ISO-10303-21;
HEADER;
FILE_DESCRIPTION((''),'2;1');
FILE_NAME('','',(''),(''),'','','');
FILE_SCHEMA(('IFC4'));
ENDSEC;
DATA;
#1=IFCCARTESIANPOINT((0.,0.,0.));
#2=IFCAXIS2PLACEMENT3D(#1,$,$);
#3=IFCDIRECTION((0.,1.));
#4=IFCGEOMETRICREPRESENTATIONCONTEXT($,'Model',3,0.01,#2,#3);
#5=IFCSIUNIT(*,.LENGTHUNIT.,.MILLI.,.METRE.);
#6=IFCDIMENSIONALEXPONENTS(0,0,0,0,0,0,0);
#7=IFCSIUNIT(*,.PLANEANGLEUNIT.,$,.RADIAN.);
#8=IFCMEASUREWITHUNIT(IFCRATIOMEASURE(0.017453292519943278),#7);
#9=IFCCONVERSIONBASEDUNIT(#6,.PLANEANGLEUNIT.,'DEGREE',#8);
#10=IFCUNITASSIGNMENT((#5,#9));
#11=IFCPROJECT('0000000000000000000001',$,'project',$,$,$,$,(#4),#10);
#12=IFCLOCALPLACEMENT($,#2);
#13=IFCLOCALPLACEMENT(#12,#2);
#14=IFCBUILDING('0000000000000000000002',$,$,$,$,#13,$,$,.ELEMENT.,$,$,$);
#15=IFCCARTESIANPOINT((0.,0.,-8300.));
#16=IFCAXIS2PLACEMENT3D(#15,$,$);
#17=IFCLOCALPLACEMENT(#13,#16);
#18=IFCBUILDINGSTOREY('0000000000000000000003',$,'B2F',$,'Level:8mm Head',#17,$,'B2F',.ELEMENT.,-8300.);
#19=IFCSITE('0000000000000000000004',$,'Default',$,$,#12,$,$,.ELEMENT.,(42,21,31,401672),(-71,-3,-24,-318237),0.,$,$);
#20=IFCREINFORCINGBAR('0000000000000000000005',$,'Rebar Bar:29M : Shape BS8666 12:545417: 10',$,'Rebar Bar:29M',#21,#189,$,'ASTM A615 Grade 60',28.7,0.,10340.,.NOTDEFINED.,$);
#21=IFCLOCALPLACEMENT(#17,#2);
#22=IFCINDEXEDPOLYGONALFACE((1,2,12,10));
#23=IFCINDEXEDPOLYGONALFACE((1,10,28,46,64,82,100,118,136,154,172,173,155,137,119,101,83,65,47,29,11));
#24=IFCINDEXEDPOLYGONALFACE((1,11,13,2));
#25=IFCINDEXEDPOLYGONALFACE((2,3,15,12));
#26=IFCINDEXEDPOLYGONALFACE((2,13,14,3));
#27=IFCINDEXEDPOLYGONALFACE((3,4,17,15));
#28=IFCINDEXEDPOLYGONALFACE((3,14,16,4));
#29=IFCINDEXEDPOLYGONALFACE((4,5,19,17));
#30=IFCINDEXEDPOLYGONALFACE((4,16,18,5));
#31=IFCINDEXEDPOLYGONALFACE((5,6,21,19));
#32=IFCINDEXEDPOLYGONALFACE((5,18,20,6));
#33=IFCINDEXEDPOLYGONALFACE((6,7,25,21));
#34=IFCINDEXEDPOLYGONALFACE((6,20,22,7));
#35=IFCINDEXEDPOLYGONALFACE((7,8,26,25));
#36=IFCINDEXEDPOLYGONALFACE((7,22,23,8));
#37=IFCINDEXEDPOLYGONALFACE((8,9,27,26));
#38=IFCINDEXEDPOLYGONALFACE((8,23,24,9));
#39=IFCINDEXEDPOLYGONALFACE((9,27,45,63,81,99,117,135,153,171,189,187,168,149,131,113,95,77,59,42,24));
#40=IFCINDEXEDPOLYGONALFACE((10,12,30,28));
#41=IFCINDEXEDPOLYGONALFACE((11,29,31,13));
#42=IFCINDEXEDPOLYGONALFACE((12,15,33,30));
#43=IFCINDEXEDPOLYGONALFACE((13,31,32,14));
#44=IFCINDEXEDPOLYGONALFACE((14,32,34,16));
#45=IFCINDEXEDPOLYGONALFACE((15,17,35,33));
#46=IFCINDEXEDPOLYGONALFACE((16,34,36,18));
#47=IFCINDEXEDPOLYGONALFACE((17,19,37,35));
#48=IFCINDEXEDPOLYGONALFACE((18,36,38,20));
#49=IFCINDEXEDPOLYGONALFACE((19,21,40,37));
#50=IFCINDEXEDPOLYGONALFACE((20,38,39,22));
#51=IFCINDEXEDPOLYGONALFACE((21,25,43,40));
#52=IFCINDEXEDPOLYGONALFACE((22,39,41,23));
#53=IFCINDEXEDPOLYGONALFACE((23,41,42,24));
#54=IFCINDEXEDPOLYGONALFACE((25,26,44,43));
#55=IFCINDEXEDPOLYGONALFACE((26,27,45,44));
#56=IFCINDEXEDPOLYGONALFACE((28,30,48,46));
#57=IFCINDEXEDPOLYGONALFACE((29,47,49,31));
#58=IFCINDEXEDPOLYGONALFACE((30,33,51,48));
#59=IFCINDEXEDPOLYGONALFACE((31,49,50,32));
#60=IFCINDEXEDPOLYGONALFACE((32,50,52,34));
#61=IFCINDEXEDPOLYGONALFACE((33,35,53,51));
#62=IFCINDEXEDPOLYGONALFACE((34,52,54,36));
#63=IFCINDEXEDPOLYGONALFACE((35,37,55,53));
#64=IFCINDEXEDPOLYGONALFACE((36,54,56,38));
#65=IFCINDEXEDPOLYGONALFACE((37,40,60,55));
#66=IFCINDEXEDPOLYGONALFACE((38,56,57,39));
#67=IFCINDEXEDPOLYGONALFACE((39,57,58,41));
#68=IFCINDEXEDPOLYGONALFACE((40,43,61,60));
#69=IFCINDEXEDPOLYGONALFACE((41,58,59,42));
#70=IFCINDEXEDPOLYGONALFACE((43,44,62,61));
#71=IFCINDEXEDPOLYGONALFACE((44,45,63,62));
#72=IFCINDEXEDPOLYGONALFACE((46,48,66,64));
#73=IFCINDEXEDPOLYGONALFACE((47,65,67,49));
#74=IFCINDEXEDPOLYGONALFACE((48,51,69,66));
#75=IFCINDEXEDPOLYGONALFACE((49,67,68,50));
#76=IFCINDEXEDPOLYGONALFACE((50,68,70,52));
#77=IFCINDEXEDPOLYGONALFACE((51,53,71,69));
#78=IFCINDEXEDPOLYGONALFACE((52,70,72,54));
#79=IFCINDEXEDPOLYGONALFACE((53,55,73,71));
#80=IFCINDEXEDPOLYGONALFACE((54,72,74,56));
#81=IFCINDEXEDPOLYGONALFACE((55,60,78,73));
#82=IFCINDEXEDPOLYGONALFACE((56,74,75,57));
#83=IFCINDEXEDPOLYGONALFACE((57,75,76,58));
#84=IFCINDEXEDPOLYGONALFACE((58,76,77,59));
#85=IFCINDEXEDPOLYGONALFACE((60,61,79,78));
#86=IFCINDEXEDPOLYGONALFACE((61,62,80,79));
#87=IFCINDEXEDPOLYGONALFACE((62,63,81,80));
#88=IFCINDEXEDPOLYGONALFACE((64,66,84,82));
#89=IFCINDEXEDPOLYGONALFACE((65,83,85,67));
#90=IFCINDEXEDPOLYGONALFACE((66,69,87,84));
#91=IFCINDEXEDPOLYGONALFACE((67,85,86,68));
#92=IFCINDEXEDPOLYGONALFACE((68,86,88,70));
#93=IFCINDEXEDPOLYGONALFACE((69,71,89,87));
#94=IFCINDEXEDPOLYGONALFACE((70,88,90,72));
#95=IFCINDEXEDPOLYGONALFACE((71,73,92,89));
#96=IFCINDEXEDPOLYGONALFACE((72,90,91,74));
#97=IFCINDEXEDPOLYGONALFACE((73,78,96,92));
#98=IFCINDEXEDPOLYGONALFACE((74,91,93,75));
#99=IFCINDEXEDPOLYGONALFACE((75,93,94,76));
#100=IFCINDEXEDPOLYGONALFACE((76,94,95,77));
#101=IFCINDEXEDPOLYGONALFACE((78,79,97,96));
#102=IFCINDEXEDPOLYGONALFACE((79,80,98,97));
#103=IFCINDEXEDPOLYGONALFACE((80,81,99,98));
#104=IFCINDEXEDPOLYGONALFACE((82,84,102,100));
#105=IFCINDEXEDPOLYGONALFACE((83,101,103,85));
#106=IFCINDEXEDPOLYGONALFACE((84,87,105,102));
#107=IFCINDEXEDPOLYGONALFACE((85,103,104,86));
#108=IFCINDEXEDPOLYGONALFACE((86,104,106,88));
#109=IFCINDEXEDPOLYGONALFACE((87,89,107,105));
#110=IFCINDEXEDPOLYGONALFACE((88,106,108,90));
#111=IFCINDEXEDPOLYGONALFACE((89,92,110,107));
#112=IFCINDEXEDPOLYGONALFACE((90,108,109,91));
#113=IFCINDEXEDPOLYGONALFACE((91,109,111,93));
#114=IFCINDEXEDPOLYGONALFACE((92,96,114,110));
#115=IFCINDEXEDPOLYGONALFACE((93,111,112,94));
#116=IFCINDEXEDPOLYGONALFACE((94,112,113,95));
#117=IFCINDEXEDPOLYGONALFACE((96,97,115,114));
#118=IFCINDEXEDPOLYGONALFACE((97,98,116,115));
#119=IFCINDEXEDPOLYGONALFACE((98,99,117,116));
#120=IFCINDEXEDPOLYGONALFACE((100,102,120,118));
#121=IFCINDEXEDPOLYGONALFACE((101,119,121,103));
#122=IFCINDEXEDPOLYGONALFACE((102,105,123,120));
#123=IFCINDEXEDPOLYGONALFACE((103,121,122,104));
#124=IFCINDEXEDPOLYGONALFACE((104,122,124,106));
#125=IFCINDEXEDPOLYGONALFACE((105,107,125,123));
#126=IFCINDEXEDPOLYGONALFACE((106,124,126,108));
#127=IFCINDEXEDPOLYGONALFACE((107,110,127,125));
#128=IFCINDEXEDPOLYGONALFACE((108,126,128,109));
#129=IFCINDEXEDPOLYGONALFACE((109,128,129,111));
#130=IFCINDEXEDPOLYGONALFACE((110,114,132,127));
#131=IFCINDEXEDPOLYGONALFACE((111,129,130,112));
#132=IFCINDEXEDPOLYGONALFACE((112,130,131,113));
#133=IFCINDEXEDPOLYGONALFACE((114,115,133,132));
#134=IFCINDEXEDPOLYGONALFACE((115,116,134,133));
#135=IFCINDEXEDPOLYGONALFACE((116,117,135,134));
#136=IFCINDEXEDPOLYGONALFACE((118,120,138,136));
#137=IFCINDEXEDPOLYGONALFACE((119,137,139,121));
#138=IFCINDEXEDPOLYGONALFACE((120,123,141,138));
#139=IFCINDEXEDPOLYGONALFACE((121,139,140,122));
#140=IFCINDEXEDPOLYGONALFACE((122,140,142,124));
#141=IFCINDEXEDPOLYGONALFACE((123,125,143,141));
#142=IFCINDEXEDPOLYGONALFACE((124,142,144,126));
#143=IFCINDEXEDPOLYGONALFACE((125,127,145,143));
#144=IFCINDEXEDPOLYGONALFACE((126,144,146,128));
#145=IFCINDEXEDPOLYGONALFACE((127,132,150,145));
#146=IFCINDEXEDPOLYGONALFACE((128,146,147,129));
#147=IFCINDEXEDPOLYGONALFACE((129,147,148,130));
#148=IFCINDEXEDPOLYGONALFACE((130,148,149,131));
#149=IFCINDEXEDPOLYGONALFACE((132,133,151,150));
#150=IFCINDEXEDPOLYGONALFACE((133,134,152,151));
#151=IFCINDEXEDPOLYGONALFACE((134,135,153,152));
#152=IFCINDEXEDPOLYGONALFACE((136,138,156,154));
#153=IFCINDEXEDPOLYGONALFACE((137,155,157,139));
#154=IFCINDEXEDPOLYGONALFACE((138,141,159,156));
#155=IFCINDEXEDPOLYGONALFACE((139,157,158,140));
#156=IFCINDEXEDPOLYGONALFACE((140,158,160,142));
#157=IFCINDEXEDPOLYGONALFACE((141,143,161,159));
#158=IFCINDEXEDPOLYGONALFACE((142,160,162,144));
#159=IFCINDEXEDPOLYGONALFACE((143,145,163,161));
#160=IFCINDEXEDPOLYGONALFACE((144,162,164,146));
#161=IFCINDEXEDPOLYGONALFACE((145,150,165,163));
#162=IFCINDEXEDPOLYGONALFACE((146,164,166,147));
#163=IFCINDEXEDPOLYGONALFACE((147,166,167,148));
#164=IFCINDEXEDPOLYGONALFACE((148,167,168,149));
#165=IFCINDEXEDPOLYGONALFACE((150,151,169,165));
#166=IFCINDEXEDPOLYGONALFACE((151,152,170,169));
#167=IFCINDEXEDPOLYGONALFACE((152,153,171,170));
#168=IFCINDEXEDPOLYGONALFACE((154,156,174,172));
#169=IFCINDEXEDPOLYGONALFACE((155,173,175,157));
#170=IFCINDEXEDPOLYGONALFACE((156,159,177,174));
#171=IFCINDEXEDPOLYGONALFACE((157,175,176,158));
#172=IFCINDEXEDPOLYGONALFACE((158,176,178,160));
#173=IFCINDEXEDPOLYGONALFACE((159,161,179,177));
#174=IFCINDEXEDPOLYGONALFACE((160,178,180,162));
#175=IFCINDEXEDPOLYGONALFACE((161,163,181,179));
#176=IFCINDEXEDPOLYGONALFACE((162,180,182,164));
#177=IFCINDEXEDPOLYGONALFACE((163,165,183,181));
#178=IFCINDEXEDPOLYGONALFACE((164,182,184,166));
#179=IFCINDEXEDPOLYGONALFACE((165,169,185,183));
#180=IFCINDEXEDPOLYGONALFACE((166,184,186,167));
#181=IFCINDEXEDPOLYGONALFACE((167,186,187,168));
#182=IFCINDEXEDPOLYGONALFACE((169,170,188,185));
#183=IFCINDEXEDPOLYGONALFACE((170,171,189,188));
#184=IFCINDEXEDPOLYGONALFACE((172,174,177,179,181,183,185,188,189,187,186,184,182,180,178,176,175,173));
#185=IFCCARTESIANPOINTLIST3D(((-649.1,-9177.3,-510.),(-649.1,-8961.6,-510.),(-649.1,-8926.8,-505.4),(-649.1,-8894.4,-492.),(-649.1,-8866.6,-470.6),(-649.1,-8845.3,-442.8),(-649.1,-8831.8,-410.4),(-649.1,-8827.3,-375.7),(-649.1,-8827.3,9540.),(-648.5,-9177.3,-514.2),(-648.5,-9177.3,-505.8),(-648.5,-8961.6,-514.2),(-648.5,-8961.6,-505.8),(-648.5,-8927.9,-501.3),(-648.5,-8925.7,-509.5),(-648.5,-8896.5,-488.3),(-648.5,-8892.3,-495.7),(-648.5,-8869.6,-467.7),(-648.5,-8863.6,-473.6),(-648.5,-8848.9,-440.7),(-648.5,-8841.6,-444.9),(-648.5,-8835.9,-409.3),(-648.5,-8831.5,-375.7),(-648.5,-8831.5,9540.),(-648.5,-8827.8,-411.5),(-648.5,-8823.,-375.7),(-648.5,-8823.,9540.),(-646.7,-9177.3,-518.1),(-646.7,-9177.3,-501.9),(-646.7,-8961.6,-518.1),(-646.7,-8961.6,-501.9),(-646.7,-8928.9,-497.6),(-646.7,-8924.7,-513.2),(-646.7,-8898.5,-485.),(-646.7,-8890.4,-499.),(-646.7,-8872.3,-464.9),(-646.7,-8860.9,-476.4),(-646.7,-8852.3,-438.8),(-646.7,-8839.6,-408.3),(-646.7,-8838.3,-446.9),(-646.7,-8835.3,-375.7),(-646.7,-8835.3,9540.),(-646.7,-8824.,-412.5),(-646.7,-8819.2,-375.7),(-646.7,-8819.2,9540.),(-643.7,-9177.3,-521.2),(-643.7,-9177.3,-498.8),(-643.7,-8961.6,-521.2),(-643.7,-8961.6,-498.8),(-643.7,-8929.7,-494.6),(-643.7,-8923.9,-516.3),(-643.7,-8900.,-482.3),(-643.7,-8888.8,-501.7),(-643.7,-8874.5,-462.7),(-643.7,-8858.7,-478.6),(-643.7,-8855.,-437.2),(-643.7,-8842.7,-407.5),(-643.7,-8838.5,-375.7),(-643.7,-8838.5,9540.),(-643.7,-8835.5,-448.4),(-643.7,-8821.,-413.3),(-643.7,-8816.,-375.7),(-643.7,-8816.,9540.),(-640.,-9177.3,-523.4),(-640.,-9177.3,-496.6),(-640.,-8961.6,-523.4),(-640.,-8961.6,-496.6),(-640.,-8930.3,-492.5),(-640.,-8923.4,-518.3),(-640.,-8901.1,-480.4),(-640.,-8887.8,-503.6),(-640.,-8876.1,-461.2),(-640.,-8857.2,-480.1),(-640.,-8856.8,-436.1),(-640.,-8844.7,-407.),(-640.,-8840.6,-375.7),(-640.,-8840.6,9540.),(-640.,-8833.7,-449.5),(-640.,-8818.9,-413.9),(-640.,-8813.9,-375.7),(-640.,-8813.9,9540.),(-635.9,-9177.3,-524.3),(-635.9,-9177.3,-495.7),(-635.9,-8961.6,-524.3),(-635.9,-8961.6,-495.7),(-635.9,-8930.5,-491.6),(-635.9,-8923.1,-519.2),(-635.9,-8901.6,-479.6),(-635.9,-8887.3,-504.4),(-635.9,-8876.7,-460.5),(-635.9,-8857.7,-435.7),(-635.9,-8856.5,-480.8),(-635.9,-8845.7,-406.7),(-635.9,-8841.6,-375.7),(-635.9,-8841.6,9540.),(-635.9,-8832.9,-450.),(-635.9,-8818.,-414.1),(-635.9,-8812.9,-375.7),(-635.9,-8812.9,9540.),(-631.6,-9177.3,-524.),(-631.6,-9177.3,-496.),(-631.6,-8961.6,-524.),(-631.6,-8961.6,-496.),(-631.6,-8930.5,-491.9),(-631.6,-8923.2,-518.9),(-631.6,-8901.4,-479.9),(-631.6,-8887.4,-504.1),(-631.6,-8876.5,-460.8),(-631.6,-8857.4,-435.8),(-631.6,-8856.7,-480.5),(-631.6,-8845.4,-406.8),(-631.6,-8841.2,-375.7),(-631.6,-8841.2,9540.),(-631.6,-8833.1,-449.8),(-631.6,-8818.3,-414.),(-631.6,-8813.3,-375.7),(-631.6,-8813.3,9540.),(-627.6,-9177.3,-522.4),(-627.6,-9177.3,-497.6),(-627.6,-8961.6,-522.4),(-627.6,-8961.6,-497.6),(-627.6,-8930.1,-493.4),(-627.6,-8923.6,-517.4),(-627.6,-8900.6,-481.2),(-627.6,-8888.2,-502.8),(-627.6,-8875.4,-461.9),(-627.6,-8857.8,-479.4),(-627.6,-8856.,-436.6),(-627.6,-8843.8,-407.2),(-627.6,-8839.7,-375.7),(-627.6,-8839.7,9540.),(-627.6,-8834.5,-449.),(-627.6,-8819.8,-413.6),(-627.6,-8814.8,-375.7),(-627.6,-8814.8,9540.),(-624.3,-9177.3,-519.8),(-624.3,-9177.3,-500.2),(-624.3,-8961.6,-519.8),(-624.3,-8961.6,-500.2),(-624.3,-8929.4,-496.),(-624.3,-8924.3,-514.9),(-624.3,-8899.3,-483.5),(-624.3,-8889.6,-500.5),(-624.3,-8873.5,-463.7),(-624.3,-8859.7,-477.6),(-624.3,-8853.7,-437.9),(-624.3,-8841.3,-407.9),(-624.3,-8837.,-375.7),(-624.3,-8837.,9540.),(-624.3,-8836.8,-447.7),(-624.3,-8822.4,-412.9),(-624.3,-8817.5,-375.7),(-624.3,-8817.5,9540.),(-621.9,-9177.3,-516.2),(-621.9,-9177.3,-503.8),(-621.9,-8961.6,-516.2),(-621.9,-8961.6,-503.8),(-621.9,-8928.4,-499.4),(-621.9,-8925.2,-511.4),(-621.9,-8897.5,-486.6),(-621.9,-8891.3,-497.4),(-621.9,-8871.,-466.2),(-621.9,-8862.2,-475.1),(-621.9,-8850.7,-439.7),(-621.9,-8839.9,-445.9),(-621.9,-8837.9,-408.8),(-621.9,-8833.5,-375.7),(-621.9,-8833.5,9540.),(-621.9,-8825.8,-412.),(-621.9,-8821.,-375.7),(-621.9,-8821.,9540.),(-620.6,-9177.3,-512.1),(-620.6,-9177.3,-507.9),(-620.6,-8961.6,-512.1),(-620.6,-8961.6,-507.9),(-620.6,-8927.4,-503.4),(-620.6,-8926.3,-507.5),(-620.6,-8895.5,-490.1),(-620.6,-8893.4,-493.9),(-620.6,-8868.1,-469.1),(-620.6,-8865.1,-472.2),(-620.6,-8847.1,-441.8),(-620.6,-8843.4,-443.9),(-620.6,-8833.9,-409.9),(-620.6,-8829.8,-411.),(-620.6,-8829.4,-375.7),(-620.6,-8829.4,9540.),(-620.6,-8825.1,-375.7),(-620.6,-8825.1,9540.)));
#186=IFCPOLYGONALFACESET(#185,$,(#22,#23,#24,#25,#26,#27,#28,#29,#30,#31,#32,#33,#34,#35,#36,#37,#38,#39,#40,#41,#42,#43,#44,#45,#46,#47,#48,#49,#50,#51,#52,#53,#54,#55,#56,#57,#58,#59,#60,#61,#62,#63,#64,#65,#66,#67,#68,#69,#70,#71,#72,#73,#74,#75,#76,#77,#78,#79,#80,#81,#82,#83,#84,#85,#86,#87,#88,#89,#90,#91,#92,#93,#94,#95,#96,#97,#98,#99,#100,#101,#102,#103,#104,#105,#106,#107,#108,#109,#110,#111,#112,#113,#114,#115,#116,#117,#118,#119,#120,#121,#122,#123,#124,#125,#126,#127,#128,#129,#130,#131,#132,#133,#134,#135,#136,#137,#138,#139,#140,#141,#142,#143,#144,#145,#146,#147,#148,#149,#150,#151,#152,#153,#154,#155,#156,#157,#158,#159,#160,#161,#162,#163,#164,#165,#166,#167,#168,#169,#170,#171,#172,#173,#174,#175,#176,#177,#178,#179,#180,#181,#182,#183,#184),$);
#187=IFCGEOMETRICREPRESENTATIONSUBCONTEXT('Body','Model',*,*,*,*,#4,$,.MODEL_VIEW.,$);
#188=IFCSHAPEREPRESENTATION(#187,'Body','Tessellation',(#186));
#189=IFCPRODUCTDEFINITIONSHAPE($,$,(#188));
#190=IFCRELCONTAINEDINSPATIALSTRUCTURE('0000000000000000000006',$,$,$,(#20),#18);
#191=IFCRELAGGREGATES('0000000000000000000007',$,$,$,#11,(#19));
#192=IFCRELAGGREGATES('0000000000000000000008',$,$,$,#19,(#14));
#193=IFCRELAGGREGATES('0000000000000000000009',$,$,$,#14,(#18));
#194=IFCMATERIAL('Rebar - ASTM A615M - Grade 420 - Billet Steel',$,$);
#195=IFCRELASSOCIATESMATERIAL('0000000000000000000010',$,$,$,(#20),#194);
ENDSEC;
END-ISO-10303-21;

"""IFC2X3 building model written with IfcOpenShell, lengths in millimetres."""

from ifc_helpers import new_model, entity, si_unit, converted_unit, direction, frame, origin, place, context, subcontext, project, spatial, material, element, save


model = new_model("IFC2X3")

# Units and contexts
model_context = context("Model", 3, precision=0.01, world=origin(), true_north=direction((0.0, 1.0)))
body_context = subcontext(model_context, "Body", "Model", "MODEL_VIEW")
ifc_project = project(units=[si_unit("LENGTHUNIT", "METRE", prefix="MILLI"), converted_unit("PLANEANGLEUNIT", "DEGREE", entity("IfcRatioMeasure", 0.017453292519943278), si_unit("PLANEANGLEUNIT", "RADIAN"), dimensions=[0, 0, 0, 0, 0, 0, 0])], contexts=[model_context])

# Site, building, storey
site_placement = place(None, origin())
site = spatial("IfcSite", under=ifc_project, at=site_placement, Name="Default", CompositionType="ELEMENT", RefLatitude=(42, 21, 31, 401672), RefLongitude=(-71, -3, -24, -318237), RefElevation=0.0)
building_placement = place(site_placement, origin())
building = spatial("IfcBuilding", under=site, at=building_placement, CompositionType="ELEMENT")
storey_placement = place(building_placement, frame((0.0, 0.0, -8300.0)))
storey = spatial("IfcBuildingStorey", under=building, at=storey_placement, Name="B2F", ObjectType="Level:8mm Head", LongName="B2F", CompositionType="ELEMENT", Elevation=-8300.0)

# Reinforcing bar
ifc_material_1 = material(Name="Rebar - ASTM A615M - Grade 420 - Billet Steel")
reinforcing_bar_1_placement = place(storey_placement, origin())
element("IfcReinforcingBar", 1, at=reinforcing_bar_1_placement, inside=storey, material=ifc_material_1, Name="Rebar Bar:29M : Shape BS8666 12:545417: 10", SteelGrade="ASTM A615 Grade 60", ObjectType="Rebar Bar:29M", BarLength=10340.0, BarRole="NOTDEFINED", CrossSectionArea=0.0, NominalDiameter=28.7, context=body_context, shape_type="AdvancedSweptSolid", body=[
    entity("IfcSweptDiskSolid", entity("IfcCompositeCurve", [entity("IfcCompositeCurveSegment", "CONTINUOUS", True, entity("IfcPolyline", [entity("IfcCartesianPoint", [-634.8, -8827.3, 9540.0]), entity("IfcCartesianPoint", [-634.8, -8827.3, -375.7])])), entity("IfcCompositeCurveSegment", "CONTINUOUS", True, entity("IfcTrimmedCurve", entity("IfcCircle", entity("IfcAxis2Placement3D", entity("IfcCartesianPoint", [-634.8, -8961.6, -375.7]), entity("IfcDirection", [-1.0, 0.0, 0.0]), entity("IfcDirection", [0.0, 0.0, -1.0])), 134.3), [entity("IfcParameterValue", 270.0)], [entity("IfcParameterValue", 360.0)], True, "PARAMETER")), entity("IfcCompositeCurveSegment", "CONTINUOUS", True, entity("IfcPolyline", [entity("IfcCartesianPoint", [-634.8, -8961.6, -510.0]), entity("IfcCartesianPoint", [-634.8, -9177.3, -510.0])]))], False), 14.3, None, 0.0, 92.0),
])

save(model, "model.ifc")
